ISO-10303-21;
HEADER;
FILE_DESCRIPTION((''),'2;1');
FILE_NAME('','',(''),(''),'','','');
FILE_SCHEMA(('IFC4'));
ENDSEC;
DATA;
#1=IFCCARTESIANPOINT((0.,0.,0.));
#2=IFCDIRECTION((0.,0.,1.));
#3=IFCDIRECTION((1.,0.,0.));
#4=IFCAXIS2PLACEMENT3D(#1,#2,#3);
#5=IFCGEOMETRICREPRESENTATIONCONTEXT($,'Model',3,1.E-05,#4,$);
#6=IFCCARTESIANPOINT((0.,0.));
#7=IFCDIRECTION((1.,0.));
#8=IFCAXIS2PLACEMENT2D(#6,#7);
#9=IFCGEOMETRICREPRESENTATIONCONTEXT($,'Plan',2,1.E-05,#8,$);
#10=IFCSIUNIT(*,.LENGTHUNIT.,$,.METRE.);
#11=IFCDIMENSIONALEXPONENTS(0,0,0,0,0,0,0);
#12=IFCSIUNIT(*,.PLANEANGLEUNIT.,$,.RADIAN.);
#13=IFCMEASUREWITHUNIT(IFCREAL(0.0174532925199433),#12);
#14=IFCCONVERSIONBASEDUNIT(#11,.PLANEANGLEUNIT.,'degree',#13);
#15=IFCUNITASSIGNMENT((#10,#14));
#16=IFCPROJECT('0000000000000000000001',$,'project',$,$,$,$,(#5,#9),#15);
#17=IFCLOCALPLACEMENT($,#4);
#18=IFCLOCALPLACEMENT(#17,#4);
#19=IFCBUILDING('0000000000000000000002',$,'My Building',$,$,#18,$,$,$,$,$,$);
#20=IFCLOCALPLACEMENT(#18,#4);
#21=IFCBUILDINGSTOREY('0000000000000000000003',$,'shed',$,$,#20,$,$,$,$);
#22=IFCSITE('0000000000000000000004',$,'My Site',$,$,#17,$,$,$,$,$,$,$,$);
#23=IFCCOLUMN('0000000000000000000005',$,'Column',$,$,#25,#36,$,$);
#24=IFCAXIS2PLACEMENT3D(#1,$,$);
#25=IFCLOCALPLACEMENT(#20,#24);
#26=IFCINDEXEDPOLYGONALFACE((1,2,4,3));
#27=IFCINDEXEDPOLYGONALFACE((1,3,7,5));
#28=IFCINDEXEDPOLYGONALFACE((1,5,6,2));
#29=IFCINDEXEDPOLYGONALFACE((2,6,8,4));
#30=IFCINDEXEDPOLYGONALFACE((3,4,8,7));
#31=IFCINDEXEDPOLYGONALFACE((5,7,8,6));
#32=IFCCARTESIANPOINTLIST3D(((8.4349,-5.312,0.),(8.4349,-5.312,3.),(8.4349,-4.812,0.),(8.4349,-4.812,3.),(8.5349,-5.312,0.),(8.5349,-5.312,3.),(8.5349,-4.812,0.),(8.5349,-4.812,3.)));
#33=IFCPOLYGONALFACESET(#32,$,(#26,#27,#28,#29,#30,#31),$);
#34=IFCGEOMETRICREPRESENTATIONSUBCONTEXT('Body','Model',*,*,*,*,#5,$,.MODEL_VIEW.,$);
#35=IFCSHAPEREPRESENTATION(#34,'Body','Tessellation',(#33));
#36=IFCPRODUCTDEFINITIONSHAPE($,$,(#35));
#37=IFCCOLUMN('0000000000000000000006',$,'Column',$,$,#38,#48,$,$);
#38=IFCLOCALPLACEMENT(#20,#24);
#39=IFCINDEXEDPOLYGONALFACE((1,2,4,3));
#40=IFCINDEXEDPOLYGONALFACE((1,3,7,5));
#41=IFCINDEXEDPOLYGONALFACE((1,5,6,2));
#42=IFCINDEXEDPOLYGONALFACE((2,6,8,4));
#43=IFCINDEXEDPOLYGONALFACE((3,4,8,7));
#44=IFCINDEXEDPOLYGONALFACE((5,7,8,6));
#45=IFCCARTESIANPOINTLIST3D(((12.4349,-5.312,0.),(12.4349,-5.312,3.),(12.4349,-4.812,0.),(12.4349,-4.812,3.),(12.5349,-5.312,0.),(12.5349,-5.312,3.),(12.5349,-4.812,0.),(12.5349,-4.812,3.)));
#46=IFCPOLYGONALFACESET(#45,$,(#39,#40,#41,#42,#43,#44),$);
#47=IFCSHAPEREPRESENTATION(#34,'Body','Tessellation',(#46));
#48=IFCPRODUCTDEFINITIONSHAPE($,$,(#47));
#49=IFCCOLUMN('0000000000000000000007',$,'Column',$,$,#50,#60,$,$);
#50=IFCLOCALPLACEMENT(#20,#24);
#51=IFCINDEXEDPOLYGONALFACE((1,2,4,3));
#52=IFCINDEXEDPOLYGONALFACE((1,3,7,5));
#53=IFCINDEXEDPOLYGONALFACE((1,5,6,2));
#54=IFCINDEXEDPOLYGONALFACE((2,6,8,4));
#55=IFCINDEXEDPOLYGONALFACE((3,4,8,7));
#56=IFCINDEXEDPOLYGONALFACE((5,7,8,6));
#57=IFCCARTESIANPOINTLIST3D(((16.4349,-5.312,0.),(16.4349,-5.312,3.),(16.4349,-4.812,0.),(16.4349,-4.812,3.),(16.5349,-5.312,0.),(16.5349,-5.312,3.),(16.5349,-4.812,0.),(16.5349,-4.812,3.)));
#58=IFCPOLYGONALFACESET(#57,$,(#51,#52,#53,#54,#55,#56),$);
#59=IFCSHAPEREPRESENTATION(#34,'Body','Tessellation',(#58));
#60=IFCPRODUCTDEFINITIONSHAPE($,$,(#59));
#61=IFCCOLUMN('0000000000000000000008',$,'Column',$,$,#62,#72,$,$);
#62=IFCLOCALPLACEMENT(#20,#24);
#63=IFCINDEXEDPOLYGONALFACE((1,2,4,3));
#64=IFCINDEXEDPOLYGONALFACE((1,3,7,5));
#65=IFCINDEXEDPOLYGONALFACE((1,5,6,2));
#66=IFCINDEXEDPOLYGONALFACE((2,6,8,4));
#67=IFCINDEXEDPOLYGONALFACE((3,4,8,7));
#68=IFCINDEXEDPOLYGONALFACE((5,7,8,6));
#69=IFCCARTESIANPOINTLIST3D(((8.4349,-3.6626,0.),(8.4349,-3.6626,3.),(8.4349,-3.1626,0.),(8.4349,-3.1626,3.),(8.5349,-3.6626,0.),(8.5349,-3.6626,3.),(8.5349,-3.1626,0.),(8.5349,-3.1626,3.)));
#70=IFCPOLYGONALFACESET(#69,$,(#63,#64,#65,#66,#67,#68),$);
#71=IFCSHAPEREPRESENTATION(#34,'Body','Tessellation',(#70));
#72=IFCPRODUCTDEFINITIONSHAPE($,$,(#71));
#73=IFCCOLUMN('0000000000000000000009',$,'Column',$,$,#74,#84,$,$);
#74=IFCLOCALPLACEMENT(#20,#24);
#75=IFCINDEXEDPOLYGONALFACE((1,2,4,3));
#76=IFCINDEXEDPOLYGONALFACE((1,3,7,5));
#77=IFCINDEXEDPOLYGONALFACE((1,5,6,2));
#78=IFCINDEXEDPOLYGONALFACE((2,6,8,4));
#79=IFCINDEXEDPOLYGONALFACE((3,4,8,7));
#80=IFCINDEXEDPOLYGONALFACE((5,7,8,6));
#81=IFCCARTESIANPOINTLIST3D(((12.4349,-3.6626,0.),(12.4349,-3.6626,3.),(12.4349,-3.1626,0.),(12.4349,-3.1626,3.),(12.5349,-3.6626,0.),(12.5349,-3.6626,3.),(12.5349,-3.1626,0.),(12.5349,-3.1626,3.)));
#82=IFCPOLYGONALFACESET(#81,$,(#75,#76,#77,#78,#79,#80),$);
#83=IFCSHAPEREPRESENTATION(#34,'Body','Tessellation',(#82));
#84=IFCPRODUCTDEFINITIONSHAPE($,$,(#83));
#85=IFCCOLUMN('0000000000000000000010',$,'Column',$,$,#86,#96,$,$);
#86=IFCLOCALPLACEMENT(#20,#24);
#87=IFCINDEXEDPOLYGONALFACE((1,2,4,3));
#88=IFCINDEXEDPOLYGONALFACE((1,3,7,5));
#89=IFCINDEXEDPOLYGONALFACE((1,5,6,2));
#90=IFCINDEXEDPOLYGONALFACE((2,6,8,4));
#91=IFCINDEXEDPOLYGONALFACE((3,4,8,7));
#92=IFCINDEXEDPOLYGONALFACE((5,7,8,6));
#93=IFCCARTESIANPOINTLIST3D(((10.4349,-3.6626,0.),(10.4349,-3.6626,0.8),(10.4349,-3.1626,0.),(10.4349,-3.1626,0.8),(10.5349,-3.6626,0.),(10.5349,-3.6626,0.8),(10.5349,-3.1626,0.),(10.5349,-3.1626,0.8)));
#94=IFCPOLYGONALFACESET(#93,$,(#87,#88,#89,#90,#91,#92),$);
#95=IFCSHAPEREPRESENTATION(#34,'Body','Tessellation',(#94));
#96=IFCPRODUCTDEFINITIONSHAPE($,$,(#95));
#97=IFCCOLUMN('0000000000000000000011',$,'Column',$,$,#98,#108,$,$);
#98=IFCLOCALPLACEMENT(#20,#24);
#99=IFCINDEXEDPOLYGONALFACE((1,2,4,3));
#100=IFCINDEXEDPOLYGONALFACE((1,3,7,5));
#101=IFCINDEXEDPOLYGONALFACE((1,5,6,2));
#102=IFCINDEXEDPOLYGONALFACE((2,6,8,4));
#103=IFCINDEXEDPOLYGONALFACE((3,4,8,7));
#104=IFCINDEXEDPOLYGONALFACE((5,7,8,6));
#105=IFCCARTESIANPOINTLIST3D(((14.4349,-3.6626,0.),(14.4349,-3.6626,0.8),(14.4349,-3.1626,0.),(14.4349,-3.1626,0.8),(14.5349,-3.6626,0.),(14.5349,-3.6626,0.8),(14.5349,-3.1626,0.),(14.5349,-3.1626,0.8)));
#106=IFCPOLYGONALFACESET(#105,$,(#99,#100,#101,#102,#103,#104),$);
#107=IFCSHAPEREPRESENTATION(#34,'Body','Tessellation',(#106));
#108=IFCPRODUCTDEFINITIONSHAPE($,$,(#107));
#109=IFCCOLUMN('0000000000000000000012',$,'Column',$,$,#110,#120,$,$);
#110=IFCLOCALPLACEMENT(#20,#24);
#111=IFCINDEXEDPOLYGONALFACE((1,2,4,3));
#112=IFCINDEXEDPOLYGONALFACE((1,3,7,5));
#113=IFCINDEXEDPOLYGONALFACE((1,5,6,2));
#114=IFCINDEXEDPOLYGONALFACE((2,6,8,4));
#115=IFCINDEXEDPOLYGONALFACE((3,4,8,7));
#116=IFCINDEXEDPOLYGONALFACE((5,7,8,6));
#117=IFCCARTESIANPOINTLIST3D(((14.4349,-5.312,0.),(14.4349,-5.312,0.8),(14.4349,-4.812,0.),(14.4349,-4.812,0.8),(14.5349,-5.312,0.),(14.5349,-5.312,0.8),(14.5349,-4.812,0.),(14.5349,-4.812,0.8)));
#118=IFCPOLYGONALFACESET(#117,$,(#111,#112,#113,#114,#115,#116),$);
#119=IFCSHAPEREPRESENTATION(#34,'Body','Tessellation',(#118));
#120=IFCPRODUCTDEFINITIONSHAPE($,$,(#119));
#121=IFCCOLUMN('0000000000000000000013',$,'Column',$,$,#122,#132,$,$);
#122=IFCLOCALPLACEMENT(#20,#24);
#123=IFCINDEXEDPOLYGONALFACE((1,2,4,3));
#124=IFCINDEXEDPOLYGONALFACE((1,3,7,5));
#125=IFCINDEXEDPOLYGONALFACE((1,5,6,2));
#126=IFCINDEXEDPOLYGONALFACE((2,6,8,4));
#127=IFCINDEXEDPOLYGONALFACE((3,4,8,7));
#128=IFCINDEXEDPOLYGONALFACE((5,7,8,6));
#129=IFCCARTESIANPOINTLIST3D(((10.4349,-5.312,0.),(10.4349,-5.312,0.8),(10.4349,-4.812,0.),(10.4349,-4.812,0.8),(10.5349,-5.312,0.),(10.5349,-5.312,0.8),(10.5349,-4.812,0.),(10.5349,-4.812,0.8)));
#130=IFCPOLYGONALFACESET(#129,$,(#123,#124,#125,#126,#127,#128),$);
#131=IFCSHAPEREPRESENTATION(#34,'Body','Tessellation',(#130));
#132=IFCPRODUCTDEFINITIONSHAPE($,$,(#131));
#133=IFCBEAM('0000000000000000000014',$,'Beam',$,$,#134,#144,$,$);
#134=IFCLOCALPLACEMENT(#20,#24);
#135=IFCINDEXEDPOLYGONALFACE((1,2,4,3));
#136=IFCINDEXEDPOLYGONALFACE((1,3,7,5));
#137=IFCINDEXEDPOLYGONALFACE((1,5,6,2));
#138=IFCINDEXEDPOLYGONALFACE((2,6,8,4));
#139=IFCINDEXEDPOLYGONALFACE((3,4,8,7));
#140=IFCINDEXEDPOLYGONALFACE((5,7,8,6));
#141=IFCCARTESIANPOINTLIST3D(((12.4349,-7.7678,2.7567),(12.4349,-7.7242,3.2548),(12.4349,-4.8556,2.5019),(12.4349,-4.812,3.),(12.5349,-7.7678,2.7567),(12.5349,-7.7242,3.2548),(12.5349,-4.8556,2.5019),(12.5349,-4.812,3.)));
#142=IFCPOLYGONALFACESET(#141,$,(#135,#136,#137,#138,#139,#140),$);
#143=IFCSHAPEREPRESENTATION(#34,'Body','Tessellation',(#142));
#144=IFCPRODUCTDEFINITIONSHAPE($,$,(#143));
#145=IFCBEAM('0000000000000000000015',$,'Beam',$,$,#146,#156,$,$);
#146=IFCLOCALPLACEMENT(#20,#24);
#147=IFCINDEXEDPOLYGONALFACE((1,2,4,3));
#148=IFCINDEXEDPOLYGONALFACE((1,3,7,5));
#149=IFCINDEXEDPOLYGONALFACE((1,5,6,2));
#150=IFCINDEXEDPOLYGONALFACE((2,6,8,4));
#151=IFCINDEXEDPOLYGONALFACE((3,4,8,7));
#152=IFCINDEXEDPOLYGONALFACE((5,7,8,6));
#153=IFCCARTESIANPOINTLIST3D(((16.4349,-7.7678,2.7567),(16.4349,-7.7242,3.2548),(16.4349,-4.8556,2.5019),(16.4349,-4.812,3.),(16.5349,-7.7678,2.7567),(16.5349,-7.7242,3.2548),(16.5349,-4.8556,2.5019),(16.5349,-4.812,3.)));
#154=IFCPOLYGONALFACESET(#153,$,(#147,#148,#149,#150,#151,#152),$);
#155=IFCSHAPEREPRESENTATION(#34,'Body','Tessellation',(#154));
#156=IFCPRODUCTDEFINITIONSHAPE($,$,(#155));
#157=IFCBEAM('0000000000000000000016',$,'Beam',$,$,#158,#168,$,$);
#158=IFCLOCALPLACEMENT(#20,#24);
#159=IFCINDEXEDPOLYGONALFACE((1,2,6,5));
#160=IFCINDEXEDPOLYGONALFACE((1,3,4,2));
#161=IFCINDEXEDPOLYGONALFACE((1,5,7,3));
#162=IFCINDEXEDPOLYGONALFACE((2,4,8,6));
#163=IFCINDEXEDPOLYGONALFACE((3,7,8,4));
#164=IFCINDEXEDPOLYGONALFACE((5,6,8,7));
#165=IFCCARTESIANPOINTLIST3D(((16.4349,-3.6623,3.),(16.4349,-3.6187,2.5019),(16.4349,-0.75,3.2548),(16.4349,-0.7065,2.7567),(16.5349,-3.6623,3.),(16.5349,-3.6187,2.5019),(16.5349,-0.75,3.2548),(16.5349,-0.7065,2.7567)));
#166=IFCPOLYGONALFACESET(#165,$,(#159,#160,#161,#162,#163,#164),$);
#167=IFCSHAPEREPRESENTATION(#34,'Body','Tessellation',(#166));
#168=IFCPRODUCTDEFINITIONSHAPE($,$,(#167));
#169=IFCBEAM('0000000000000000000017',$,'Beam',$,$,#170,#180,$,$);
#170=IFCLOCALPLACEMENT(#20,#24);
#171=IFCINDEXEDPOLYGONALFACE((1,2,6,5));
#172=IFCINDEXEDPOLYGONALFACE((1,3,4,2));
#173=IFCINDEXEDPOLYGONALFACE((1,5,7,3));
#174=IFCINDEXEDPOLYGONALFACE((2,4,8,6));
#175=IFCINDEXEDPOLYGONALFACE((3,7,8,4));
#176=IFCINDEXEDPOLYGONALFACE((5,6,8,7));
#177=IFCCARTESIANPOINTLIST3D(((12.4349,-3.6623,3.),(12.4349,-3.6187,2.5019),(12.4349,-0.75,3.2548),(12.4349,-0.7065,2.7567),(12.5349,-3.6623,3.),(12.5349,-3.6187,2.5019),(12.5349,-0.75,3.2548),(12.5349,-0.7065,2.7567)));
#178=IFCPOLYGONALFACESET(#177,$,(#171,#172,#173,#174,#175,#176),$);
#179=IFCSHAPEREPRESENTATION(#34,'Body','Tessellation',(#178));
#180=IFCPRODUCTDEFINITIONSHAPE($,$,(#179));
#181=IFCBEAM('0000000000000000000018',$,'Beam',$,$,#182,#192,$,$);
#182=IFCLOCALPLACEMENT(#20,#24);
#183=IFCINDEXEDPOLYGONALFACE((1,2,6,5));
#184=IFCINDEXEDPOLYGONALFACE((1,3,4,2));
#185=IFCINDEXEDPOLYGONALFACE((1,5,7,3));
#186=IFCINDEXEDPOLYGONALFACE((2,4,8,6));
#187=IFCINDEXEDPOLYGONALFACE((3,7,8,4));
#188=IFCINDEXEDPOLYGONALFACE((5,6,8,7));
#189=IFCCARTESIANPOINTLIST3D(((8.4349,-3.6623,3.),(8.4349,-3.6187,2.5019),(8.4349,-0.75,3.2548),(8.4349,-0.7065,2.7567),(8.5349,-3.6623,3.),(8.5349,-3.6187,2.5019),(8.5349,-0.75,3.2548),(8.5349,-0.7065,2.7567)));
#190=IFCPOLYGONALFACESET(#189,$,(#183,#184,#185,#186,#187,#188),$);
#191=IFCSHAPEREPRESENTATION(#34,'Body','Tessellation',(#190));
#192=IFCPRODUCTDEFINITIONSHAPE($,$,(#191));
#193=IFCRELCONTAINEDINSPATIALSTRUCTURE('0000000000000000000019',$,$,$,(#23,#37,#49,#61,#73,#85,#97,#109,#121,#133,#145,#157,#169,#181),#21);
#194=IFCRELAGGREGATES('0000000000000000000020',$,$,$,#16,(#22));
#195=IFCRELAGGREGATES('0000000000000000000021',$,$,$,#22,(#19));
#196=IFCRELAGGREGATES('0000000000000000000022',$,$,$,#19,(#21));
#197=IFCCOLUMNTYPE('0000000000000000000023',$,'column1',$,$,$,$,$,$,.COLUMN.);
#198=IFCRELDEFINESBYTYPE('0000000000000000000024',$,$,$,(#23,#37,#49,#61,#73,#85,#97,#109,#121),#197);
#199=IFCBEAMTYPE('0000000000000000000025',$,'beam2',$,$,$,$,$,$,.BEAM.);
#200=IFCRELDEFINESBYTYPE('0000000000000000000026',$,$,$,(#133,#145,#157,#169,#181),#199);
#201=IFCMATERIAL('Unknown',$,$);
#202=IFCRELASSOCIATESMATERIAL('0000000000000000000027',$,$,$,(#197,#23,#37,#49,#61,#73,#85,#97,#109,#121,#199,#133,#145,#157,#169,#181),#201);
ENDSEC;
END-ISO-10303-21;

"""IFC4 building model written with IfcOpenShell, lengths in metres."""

from ifc_helpers import new_model, entity, si_unit, converted_unit, frame, origin_with_axes, origin_2d_with_axis, place, context, subcontext, project, spatial, rectangle, extrude, material, material_profile, profile_set, profile_usage, type_object, element, save


model = new_model("IFC4")

# Units and contexts
model_context = context("Model", 3, precision=1e-05, world=origin_with_axes())
plan_context = context("Plan", 2, precision=1e-05, world=origin_2d_with_axis())
body_context = subcontext(model_context, "Body", "Model", "MODEL_VIEW")
ifc_project = project(units=[si_unit("LENGTHUNIT", "METRE"), converted_unit("PLANEANGLEUNIT", "degree", entity("IfcReal", 0.0174532925199433), si_unit("PLANEANGLEUNIT", "RADIAN"), dimensions=[0, 0, 0, 0, 0, 0, 0])], contexts=[model_context, plan_context])

# Site, building, storey
site_placement = place(None, origin_with_axes())
site = spatial("IfcSite", under=ifc_project, at=site_placement, Name="My Site")
building_placement = place(site_placement, origin_with_axes())
building = spatial("IfcBuilding", under=site, at=building_placement, Name="My Building")
storey_placement = place(building_placement, origin_with_axes())
storey = spatial("IfcBuildingStorey", under=building, at=storey_placement, Name="shed")

# Columns
ifc_material = material(Name="Unknown")
ifc_material_profile_1 = material_profile(ifc_material, rectangle(XDim=0.1, YDim=0.5))
ifc_profile_set_1 = profile_set([ifc_material_profile_1])
ifc_profile_usage_1 = profile_usage(ifc_profile_set_1, cardinal=5)
column_type = type_object("IfcColumnType", Name="column1", PredefinedType="COLUMN", material=ifc_profile_set_1)
column_1_placement = place(storey_placement, frame((8.4849, -5.062, 0.0), z_axis=(0.0, 0.0, 1.0), x_axis=(1.0, 0.0, 0.0)))
element("IfcColumn", 1, at=column_1_placement, inside=storey, type_object=column_type, material=ifc_profile_usage_1, Name="Column", context=body_context, shape_type="SweptSolid", body=[
    extrude(rectangle(XDim=0.1, YDim=0.5), origin_with_axes(), (0.0, 0.0, 1.0), 3.0),
])
ifc_profile_usage_2 = profile_usage(ifc_profile_set_1, cardinal=5)
column_2_placement = place(storey_placement, frame((12.4849, -5.062, 0.0), z_axis=(0.0, 0.0, 1.0), x_axis=(1.0, 0.0, 0.0)))
element("IfcColumn", 2, at=column_2_placement, inside=storey, type_object=column_type, material=ifc_profile_usage_2, Name="Column", context=body_context, shape_type="SweptSolid", body=[
    extrude(rectangle(XDim=0.1, YDim=0.5), origin_with_axes(), (0.0, 0.0, 1.0), 3.0),
])
ifc_profile_usage_3 = profile_usage(ifc_profile_set_1, cardinal=5)
column_3_placement = place(storey_placement, frame((16.4849, -5.062, 0.0), z_axis=(0.0, 0.0, 1.0), x_axis=(1.0, 0.0, 0.0)))
element("IfcColumn", 3, at=column_3_placement, inside=storey, type_object=column_type, material=ifc_profile_usage_3, Name="Column", context=body_context, shape_type="SweptSolid", body=[
    extrude(rectangle(XDim=0.1, YDim=0.5), origin_with_axes(), (0.0, 0.0, 1.0), 3.0),
])
ifc_profile_usage_4 = profile_usage(ifc_profile_set_1, cardinal=5)
column_4_placement = place(storey_placement, frame((8.4849, -3.4126, 0.0), z_axis=(0.0, 0.0, 1.0), x_axis=(-1.0, 0.0, 0.0)))
element("IfcColumn", 4, at=column_4_placement, inside=storey, type_object=column_type, material=ifc_profile_usage_4, Name="Column", context=body_context, shape_type="SweptSolid", body=[
    extrude(rectangle(XDim=0.1, YDim=0.5), origin_with_axes(), (0.0, 0.0, 1.0), 3.0),
])
ifc_profile_usage_5 = profile_usage(ifc_profile_set_1, cardinal=5)
column_5_placement = place(storey_placement, frame((12.4849, -3.4126, 0.0), z_axis=(0.0, 0.0, 1.0), x_axis=(-1.0, 0.0, 0.0)))
element("IfcColumn", 5, at=column_5_placement, inside=storey, type_object=column_type, material=ifc_profile_usage_5, Name="Column", context=body_context, shape_type="SweptSolid", body=[
    extrude(rectangle(XDim=0.1, YDim=0.5), origin_with_axes(), (0.0, 0.0, 1.0), 3.0),
])
ifc_profile_usage_6 = profile_usage(ifc_profile_set_1, cardinal=5)
column_6_placement = place(storey_placement, frame((10.4849, -3.4126, 0.0), z_axis=(0.0, 0.0, 1.0), x_axis=(-1.0, 0.0, 0.0)))
element("IfcColumn", 6, at=column_6_placement, inside=storey, type_object=column_type, material=ifc_profile_usage_6, Name="Column", context=body_context, shape_type="SweptSolid", body=[
    extrude(rectangle(XDim=0.1, YDim=0.5), origin_with_axes(), (0.0, 0.0, 1.0), 0.8),
])
ifc_profile_usage_7 = profile_usage(ifc_profile_set_1, cardinal=5)
column_7_placement = place(storey_placement, frame((14.4849, -3.4126, 0.0), z_axis=(0.0, 0.0, 1.0), x_axis=(-1.0, 0.0, 0.0)))
element("IfcColumn", 7, at=column_7_placement, inside=storey, type_object=column_type, material=ifc_profile_usage_7, Name="Column", context=body_context, shape_type="SweptSolid", body=[
    extrude(rectangle(XDim=0.1, YDim=0.5), origin_with_axes(), (0.0, 0.0, 1.0), 0.8),
])
ifc_profile_usage_8 = profile_usage(ifc_profile_set_1, cardinal=5)
column_8_placement = place(storey_placement, frame((14.4849, -5.062, 0.0), z_axis=(0.0, 0.0, 1.0), x_axis=(-1.0, 0.0, 0.0)))
element("IfcColumn", 8, at=column_8_placement, inside=storey, type_object=column_type, material=ifc_profile_usage_8, Name="Column", context=body_context, shape_type="SweptSolid", body=[
    extrude(rectangle(XDim=0.1, YDim=0.5), origin_with_axes(), (0.0, 0.0, 1.0), 0.8),
])
ifc_profile_usage_9 = profile_usage(ifc_profile_set_1, cardinal=5)
column_9_placement = place(storey_placement, frame((10.4849, -5.062, 0.0), z_axis=(0.0, 0.0, 1.0), x_axis=(-1.0, 0.0, 0.0)))
element("IfcColumn", 9, at=column_9_placement, inside=storey, type_object=column_type, material=ifc_profile_usage_9, Name="Column", context=body_context, shape_type="SweptSolid", body=[
    extrude(rectangle(XDim=0.1, YDim=0.5), origin_with_axes(), (0.0, 0.0, 1.0), 0.8),
])

# Beams
ifc_material_profile_2 = material_profile(ifc_material, rectangle(XDim=0.1, YDim=0.5))
ifc_profile_set_2 = profile_set([ifc_material_profile_2])
ifc_profile_usage_10 = profile_usage(ifc_profile_set_2, cardinal=8)
beam_type = type_object("IfcBeamType", Name="beam2", PredefinedType="BEAM", material=ifc_profile_set_2)
beam_1_placement = place(storey_placement, frame((12.4849, -4.812, 3.0), z_axis=(0.0, -0.996195, 0.087156), x_axis=(1.0, 0.0, 0.0)))
element("IfcBeam", 10, at=beam_1_placement, inside=storey, type_object=beam_type, material=ifc_profile_usage_10, Name="Beam", context=body_context, shape_type="SweptSolid", body=[
    extrude(rectangle(XDim=0.1, YDim=0.5), frame((0.0, -0.25, 0.0), z_axis=(0.0, 0.0, 1.0), x_axis=(1.0, 0.0, 0.0)), (0.0, 0.0, 1.0), 2.9234),
])
ifc_profile_usage_11 = profile_usage(ifc_profile_set_2, cardinal=8)
beam_2_placement = place(storey_placement, frame((16.4849, -4.812, 3.0), z_axis=(0.0, -0.996195, 0.087156), x_axis=(1.0, 0.0, 0.0)))
element("IfcBeam", 11, at=beam_2_placement, inside=storey, type_object=beam_type, material=ifc_profile_usage_11, Name="Beam", context=body_context, shape_type="SweptSolid", body=[
    extrude(rectangle(XDim=0.1, YDim=0.5), frame((0.0, -0.25, 0.0), z_axis=(0.0, 0.0, 1.0), x_axis=(1.0, 0.0, 0.0)), (0.0, 0.0, 1.0), 2.9234),
])
ifc_profile_usage_12 = profile_usage(ifc_profile_set_2, cardinal=8)
beam_3_placement = place(storey_placement, frame((16.4849, -3.6623, 3.0), z_axis=(0.0, 0.996195, 0.087156), x_axis=(-1.0, 0.0, 0.0)))
element("IfcBeam", 12, at=beam_3_placement, inside=storey, type_object=beam_type, material=ifc_profile_usage_12, Name="Beam", context=body_context, shape_type="SweptSolid", body=[
    extrude(rectangle(XDim=0.1, YDim=0.5), frame((0.0, -0.25, 0.0), z_axis=(0.0, 0.0, 1.0), x_axis=(1.0, 0.0, 0.0)), (0.0, 0.0, 1.0), 2.9234),
])
ifc_profile_usage_13 = profile_usage(ifc_profile_set_2, cardinal=8)
beam_4_placement = place(storey_placement, frame((12.4849, -3.6623, 3.0), z_axis=(0.0, 0.996195, 0.087156), x_axis=(-1.0, 0.0, 0.0)))
element("IfcBeam", 13, at=beam_4_placement, inside=storey, type_object=beam_type, material=ifc_profile_usage_13, Name="Beam", context=body_context, shape_type="SweptSolid", body=[
    extrude(rectangle(XDim=0.1, YDim=0.5), frame((0.0, -0.25, 0.0), z_axis=(0.0, 0.0, 1.0), x_axis=(1.0, 0.0, 0.0)), (0.0, 0.0, 1.0), 2.9234),
])
ifc_profile_usage_14 = profile_usage(ifc_profile_set_2, cardinal=8)
beam_5_placement = place(storey_placement, frame((8.4849, -3.6623, 3.0), z_axis=(0.0, 0.996195, 0.087156), x_axis=(-1.0, 0.0, 0.0)))
element("IfcBeam", 14, at=beam_5_placement, inside=storey, type_object=beam_type, material=ifc_profile_usage_14, Name="Beam", context=body_context, shape_type="SweptSolid", body=[
    extrude(rectangle(XDim=0.1, YDim=0.5), frame((0.0, -0.25, 0.0), z_axis=(0.0, 0.0, 1.0), x_axis=(1.0, 0.0, 0.0)), (0.0, 0.0, 1.0), 2.9234),
])

save(model, "model.ifc")
